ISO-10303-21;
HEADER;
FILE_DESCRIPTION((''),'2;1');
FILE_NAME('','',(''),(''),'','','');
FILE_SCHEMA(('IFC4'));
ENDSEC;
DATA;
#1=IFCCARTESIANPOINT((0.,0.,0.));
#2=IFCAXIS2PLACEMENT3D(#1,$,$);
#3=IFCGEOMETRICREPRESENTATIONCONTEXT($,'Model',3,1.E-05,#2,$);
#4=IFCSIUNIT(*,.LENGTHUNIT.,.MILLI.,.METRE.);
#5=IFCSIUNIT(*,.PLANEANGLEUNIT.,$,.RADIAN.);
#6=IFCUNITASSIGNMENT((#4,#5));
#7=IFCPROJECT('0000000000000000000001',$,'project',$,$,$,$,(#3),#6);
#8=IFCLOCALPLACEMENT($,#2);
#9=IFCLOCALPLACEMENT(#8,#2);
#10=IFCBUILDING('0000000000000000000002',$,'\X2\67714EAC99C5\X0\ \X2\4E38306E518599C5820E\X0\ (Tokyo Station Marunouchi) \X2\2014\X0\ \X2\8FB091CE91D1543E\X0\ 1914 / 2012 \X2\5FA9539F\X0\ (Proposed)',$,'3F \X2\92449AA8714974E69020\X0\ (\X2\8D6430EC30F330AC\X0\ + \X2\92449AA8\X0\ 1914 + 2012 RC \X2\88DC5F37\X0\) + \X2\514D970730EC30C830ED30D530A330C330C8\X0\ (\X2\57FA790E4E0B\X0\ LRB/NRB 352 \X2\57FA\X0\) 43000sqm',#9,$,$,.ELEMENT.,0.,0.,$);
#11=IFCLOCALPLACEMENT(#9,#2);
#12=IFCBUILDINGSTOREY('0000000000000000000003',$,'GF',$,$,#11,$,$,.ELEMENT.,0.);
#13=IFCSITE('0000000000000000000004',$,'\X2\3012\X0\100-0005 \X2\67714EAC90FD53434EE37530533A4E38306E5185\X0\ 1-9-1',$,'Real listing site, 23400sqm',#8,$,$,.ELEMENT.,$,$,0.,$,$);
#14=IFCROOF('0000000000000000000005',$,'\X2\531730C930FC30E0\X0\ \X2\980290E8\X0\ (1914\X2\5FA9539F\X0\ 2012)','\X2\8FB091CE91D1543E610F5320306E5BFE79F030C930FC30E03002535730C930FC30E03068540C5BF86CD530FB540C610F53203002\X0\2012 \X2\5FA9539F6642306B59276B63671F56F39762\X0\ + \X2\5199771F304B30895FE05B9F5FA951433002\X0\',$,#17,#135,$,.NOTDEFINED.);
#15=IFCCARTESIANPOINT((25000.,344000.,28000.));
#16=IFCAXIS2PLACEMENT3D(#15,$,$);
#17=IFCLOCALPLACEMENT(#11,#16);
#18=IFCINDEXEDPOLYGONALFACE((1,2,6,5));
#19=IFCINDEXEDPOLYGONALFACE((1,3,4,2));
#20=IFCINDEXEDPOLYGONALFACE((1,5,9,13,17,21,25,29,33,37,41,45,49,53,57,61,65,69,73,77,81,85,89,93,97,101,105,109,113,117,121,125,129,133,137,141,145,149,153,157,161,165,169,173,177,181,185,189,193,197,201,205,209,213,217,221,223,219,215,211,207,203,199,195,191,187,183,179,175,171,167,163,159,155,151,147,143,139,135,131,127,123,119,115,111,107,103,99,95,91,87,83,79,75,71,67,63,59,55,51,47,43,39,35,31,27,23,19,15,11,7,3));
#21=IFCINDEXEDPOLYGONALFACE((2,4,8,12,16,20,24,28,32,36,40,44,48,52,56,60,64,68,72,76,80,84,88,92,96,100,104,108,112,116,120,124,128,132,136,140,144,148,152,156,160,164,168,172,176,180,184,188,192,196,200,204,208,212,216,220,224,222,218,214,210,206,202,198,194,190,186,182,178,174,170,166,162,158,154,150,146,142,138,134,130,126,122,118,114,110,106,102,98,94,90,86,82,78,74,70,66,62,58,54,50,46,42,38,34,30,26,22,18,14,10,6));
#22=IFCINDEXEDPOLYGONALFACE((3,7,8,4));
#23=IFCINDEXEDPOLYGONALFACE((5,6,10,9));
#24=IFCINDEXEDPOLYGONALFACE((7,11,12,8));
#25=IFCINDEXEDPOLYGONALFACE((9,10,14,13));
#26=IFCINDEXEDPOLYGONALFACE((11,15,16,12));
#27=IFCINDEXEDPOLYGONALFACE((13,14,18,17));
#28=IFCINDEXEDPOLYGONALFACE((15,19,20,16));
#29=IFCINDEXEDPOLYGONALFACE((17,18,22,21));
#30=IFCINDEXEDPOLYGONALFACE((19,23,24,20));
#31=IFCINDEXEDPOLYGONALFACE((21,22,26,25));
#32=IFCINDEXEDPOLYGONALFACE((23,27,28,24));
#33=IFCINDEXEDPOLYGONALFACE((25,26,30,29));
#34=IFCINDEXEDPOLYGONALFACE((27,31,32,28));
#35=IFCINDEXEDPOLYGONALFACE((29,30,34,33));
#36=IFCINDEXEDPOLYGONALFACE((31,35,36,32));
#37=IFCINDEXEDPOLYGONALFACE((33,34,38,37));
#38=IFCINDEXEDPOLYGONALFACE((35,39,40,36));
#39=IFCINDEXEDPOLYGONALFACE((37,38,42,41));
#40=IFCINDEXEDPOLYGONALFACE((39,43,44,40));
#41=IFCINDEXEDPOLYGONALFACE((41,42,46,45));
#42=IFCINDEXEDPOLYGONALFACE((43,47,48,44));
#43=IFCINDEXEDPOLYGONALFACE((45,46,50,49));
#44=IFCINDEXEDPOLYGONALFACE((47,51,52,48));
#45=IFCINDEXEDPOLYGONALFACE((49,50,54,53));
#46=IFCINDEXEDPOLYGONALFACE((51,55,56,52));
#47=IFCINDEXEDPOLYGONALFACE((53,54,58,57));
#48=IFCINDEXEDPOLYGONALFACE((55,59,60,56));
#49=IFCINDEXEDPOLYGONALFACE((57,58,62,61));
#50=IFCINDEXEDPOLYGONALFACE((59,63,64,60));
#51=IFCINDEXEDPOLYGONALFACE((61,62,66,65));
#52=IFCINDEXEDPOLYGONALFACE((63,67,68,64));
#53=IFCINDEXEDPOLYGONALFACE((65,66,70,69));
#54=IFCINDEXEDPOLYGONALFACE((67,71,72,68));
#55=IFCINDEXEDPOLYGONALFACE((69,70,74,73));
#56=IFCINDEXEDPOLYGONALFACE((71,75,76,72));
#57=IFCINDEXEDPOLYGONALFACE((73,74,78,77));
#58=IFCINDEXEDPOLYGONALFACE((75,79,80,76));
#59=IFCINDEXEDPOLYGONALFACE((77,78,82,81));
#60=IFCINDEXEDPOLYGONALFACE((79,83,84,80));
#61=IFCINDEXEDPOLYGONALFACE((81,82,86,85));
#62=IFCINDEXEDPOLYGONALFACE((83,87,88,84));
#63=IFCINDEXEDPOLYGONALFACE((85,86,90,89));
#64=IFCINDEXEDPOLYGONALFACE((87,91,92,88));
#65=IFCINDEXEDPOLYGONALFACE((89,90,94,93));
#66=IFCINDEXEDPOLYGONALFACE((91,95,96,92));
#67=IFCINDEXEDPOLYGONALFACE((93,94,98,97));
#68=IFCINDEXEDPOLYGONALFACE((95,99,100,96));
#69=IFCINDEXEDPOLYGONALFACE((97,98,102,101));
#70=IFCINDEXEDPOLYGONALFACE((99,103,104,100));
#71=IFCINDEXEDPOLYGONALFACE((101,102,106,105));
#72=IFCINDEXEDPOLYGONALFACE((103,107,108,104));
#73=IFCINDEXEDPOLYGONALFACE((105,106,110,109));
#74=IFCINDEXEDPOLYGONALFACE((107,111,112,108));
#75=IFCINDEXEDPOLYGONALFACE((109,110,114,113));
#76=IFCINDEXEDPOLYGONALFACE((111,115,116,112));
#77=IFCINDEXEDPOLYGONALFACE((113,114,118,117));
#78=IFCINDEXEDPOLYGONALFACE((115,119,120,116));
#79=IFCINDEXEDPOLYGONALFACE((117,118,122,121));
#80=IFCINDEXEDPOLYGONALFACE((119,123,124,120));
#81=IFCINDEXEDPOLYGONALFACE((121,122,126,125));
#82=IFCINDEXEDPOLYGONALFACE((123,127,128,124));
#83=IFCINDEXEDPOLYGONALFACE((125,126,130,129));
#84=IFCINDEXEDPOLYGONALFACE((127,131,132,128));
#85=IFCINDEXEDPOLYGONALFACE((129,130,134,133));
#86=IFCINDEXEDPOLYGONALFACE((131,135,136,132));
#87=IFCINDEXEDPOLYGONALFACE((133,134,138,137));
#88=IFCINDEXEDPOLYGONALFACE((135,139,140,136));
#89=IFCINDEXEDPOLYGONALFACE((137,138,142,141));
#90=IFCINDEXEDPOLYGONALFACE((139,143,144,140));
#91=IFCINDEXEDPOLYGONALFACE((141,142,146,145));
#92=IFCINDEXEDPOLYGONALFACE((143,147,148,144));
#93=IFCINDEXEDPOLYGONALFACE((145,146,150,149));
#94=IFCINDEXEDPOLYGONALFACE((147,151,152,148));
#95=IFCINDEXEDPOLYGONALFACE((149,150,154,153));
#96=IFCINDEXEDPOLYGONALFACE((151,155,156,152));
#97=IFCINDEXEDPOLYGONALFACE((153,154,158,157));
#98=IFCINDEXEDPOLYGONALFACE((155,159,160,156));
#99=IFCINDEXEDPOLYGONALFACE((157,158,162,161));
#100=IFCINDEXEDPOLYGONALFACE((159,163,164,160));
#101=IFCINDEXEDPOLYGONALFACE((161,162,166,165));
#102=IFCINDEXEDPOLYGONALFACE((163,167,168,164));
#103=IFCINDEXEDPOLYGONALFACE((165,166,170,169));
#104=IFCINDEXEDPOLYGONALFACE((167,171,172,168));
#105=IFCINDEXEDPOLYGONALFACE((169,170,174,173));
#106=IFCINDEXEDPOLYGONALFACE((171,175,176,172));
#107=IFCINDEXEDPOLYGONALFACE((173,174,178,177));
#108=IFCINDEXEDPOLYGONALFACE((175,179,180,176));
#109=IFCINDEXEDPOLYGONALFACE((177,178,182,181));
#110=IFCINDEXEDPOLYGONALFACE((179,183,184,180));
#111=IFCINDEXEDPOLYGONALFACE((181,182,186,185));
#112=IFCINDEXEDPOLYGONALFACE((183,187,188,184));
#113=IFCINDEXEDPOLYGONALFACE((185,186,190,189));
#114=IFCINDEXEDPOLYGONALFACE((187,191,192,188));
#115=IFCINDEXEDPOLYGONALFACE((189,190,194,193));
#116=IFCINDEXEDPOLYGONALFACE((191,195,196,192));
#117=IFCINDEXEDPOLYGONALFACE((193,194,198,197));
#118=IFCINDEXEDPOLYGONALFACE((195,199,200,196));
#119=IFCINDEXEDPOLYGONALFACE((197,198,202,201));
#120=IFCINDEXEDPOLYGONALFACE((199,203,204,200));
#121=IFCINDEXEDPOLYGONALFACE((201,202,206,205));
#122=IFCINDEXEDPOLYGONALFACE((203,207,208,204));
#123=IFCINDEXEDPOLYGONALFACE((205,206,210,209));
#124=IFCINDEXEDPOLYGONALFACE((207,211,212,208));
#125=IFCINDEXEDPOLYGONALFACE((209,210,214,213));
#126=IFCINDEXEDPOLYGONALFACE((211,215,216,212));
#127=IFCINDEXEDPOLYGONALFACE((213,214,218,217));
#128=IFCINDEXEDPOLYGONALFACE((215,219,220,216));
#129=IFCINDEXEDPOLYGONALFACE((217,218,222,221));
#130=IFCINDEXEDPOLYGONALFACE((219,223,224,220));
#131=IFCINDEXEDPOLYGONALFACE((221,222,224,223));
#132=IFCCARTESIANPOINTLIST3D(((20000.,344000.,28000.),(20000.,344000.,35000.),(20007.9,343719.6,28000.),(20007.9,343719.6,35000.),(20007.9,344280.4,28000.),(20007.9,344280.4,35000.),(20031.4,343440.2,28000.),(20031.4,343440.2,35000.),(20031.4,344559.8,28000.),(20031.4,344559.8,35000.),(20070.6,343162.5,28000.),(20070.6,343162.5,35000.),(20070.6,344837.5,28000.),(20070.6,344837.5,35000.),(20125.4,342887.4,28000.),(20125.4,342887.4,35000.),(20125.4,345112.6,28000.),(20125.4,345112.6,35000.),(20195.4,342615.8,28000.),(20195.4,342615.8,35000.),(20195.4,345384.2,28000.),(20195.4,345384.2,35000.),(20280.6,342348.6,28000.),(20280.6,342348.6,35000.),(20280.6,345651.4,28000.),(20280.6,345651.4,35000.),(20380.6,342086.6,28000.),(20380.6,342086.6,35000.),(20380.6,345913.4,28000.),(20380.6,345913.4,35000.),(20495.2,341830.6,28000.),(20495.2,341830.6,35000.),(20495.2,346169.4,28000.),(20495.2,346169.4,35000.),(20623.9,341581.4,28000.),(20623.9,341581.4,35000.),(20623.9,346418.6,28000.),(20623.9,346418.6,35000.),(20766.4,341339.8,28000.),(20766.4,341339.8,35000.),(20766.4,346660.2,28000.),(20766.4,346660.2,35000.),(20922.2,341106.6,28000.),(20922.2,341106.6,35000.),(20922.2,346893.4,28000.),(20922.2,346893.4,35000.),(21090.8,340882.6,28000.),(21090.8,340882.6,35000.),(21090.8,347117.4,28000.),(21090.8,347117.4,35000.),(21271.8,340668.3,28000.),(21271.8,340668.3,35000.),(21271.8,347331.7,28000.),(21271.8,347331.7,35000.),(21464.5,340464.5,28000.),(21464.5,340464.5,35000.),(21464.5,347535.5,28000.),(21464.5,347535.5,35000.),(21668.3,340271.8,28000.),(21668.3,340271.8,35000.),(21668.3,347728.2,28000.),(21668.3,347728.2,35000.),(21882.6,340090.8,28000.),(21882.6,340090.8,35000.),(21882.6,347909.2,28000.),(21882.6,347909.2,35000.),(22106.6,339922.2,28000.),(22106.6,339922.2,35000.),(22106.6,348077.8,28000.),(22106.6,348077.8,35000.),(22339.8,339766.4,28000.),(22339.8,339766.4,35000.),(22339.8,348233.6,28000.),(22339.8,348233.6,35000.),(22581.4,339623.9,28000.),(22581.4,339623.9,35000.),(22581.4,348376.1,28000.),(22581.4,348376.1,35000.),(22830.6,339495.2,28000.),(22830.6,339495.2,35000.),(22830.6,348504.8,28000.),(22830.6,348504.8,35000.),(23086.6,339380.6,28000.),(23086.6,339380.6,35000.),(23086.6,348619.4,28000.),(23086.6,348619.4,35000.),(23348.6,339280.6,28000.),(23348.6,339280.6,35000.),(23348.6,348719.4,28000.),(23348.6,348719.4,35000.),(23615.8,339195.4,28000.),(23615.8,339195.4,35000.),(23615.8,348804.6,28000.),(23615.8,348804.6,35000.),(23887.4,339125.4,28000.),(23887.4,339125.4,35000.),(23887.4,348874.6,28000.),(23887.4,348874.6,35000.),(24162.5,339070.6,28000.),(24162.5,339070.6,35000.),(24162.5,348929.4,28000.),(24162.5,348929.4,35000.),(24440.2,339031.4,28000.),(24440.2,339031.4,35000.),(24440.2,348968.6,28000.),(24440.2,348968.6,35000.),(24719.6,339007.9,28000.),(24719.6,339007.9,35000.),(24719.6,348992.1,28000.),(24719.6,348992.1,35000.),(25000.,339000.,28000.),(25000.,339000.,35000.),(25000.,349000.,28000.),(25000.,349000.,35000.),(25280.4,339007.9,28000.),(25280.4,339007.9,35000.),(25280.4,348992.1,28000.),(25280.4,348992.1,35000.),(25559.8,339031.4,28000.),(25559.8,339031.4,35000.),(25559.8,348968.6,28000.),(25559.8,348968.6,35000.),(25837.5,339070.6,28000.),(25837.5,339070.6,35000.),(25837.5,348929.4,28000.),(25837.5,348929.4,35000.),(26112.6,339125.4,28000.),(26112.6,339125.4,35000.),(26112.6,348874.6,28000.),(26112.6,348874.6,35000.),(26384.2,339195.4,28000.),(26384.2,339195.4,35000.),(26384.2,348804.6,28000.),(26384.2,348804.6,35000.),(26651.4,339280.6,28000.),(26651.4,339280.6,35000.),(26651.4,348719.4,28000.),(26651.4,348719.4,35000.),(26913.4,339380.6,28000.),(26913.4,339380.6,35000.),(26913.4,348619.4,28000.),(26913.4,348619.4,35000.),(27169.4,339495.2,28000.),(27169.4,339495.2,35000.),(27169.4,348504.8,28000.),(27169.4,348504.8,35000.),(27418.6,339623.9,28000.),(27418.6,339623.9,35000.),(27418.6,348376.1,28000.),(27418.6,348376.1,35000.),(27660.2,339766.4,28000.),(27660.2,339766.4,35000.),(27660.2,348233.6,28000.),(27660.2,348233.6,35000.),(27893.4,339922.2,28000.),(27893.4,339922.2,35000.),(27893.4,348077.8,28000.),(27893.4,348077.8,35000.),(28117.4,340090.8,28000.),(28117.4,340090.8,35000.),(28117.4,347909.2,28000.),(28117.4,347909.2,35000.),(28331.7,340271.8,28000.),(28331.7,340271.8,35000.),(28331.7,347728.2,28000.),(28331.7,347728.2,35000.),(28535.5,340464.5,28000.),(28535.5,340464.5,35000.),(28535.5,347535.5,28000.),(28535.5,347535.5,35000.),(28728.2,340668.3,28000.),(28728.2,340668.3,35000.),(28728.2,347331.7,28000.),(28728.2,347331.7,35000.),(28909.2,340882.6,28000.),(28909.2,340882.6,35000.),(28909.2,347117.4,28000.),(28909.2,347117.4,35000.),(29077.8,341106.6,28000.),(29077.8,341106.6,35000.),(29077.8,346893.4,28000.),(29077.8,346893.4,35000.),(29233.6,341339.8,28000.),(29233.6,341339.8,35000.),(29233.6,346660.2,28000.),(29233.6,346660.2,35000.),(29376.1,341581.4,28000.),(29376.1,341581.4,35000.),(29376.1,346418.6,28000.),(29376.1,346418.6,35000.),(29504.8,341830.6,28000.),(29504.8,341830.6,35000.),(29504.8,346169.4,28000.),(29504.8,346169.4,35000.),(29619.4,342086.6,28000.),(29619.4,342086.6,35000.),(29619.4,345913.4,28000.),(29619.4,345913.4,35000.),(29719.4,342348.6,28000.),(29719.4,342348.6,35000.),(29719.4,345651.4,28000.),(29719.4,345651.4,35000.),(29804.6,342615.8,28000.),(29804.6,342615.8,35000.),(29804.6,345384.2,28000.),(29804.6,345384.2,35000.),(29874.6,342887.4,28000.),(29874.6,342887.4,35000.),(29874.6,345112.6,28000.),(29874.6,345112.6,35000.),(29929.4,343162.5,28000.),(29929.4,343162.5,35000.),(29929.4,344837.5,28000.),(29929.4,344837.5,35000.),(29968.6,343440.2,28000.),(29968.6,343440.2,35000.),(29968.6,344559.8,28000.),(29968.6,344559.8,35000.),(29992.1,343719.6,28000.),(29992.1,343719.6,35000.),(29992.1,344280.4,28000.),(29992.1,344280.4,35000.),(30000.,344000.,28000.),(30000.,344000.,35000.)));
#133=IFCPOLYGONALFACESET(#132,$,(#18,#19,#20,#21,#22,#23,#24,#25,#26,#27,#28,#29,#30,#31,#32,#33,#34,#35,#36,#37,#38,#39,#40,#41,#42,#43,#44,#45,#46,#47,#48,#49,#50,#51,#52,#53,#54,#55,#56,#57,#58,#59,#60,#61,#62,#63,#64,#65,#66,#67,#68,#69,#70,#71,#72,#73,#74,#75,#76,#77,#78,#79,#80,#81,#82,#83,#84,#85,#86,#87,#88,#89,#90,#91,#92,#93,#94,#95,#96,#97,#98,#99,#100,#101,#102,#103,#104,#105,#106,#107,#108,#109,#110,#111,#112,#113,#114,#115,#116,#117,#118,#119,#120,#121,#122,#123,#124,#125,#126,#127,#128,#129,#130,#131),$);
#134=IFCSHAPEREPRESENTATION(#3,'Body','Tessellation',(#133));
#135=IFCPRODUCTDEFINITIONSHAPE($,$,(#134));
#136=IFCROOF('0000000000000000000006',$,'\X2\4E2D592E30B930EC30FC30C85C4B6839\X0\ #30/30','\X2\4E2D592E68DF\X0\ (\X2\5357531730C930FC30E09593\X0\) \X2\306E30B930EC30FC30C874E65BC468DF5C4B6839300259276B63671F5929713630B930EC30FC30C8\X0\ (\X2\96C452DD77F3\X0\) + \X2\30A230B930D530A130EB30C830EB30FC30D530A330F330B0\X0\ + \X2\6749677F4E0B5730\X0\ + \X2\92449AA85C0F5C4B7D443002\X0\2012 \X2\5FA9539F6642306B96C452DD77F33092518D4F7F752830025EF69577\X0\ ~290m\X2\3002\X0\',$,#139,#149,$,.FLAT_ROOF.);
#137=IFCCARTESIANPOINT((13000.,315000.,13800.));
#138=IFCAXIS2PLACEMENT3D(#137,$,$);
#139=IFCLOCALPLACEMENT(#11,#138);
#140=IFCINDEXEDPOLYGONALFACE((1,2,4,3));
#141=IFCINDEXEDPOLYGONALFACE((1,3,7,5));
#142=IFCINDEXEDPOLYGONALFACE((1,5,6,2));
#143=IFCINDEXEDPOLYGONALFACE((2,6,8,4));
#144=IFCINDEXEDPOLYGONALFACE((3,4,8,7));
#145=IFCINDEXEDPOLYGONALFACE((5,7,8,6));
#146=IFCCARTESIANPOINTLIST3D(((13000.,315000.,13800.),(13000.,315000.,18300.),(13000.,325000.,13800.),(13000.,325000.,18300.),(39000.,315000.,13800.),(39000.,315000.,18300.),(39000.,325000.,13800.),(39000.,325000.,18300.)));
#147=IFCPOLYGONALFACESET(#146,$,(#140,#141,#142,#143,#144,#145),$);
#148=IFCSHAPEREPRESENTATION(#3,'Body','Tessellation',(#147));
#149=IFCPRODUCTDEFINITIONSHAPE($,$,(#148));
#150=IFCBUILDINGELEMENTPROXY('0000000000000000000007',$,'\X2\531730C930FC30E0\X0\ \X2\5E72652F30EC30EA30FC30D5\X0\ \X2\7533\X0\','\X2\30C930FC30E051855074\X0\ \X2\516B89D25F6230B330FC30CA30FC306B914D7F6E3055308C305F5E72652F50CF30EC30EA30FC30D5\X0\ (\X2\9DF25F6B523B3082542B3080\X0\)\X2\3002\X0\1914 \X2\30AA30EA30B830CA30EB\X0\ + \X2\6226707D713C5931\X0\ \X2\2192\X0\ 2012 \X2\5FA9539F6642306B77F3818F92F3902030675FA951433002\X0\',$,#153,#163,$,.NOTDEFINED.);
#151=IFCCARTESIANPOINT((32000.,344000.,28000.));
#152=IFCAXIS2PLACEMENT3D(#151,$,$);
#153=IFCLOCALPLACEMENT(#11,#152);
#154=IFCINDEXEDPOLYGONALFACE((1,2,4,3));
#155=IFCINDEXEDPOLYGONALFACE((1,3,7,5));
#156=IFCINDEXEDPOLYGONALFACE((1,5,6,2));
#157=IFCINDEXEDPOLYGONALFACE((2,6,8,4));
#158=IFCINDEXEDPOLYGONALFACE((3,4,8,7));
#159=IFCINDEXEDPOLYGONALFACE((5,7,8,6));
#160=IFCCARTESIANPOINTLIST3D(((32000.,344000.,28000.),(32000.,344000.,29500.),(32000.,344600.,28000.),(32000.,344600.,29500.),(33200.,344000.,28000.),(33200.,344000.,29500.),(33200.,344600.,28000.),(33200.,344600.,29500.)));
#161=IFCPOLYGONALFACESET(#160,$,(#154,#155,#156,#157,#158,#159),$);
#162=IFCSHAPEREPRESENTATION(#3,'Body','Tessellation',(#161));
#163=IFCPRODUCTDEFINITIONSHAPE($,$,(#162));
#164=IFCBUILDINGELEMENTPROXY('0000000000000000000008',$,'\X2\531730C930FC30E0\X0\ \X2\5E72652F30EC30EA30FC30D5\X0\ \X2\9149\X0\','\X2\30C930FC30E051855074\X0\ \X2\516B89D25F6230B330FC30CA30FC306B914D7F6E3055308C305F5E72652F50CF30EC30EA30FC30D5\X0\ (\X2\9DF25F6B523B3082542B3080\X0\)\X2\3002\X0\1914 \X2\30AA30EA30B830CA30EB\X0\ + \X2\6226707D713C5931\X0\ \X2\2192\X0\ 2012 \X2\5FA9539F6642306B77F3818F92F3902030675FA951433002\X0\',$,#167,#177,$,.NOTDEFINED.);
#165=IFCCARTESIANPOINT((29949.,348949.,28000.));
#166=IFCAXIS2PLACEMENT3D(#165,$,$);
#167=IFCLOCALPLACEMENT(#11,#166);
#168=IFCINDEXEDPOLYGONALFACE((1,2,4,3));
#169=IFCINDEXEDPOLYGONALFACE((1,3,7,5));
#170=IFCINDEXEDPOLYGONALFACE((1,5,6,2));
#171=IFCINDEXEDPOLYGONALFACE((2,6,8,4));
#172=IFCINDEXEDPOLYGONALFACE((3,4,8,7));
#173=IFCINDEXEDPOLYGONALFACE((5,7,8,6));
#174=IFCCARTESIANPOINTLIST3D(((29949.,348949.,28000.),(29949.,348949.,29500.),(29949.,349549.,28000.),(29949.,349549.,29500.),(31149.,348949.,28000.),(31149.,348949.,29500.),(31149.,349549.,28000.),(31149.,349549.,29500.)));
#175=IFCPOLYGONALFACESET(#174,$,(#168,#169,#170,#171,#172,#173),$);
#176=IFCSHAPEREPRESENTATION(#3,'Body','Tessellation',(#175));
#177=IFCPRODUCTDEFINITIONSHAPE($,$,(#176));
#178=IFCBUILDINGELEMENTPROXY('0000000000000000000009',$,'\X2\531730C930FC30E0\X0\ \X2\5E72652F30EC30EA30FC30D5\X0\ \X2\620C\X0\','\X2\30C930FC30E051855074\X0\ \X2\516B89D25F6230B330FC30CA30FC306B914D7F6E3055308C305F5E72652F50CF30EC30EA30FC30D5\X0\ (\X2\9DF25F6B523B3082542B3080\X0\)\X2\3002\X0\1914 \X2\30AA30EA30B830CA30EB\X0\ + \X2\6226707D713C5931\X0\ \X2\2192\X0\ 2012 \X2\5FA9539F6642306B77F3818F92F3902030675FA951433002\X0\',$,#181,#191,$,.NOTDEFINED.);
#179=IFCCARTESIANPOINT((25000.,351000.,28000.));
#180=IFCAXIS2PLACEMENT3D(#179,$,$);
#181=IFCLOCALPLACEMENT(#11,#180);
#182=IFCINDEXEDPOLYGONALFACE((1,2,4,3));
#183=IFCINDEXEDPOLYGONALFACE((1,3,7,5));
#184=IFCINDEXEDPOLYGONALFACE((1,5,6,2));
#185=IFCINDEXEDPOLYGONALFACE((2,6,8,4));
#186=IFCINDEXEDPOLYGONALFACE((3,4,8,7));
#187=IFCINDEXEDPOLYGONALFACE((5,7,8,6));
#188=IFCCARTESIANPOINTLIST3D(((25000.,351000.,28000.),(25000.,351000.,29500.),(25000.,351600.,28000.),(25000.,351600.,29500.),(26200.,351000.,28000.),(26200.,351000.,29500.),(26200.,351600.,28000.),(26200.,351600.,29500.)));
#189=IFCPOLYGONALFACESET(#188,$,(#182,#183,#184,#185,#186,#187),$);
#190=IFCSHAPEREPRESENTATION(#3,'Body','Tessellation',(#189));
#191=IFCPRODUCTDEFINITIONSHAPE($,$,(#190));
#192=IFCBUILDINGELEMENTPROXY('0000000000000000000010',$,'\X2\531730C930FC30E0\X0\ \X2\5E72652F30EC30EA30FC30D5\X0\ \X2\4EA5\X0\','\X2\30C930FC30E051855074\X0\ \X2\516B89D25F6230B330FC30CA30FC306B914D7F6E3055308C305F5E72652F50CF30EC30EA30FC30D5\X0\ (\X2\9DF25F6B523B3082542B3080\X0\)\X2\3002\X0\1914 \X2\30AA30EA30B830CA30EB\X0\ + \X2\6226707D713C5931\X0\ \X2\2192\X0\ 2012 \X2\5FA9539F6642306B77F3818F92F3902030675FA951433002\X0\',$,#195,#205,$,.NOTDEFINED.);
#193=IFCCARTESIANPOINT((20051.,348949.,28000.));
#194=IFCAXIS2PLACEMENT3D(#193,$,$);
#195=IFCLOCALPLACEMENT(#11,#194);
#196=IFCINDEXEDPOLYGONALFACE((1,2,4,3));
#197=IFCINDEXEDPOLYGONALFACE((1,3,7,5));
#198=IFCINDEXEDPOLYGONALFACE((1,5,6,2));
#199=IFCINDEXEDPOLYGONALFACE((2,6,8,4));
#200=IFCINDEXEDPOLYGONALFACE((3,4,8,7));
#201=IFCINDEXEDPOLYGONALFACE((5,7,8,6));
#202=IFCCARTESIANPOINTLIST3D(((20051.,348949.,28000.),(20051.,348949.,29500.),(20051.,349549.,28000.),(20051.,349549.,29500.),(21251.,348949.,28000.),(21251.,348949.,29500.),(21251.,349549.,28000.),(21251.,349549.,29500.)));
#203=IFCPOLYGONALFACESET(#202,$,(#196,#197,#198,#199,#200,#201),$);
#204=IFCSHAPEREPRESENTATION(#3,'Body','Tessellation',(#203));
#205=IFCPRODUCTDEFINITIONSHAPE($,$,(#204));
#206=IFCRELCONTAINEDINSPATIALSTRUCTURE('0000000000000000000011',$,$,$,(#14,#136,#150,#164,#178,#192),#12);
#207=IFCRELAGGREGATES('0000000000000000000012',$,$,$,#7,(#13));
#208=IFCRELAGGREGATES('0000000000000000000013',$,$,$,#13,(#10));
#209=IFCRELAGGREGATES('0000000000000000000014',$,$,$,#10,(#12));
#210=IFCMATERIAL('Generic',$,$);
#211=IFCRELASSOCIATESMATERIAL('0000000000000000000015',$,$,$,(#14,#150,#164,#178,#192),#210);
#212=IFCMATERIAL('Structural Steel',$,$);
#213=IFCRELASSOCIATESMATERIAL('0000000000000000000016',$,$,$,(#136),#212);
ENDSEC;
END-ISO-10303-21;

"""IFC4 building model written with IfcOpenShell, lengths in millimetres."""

from ifc_helpers import new_model, si_unit, frame, frame_2d, origin, origin_2d, place, context, project, spatial, rectangle, circle, extrude, material, element, save


model = new_model("IFC4")

# Units and contexts
model_context = context("Model", 3, precision=1e-05, world=origin())
ifc_project = project(units=[si_unit("LENGTHUNIT", "METRE", prefix="MILLI"), si_unit("PLANEANGLEUNIT", "RADIAN")], contexts=[model_context])

# Site, building, storey
site_placement = place(None, origin())
site = spatial("IfcSite", under=ifc_project, at=site_placement, Name="〒100-0005 東京都千代田区丸の内 1-9-1", ObjectType="Real listing site, 23400sqm", CompositionType="ELEMENT", RefElevation=0.0)
building_placement = place(site_placement, origin())
building = spatial("IfcBuilding", under=site, at=building_placement, Name="東京駅 丸の内駅舎 (Tokyo Station Marunouchi) — 辰野金吾 1914 / 2012 復原 (Proposed)", ObjectType="3F 鉄骨煉瓦造 (赤レンガ + 鉄骨 1914 + 2012 RC 補強) + 免震レトロフィット (基礎下 LRB/NRB 352 基) 43000sqm", CompositionType="ELEMENT", ElevationOfRefHeight=0.0, ElevationOfTerrain=0.0)
storey_placement = place(building_placement, origin())
storey = spatial("IfcBuildingStorey", under=building, at=storey_placement, Name="GF", CompositionType="ELEMENT", Elevation=0.0)

# Shared definitions
ifc_material_1 = material(Name="Structural Steel")

# Shared definitions
ifc_material_2 = material(Name="Generic")

# Roofs
roof_1_placement = place(storey_placement, frame((25000.0, 344000.0, 28000.0)))
element("IfcRoof", 1, at=roof_1_placement, inside=storey, material=ifc_material_2, Name="北ドーム 頂部 (1914復原 2012)", Description="辰野金吾意匠の対称ドーム。南ドームと同寸法・同意匠。2012 復原時に大正期図面 + 写真から忠実復元。", PredefinedType="NOTDEFINED", context=model_context, shape_type="SweptSolid", body=[
    extrude(circle(Radius=5000.0, at=origin_2d()), frame((25000.0, 344000.0, 28000.0)), (0.0, 0.0, 1.0), 7000.0),
])
roof_2_placement = place(storey_placement, frame((13000.0, 315000.0, 13800.0)))
element("IfcRoof", 2, at=roof_2_placement, inside=storey, material=ifc_material_1, Name="中央スレート屋根 #30/30", Description="中央棟 (南北ドーム間) のスレート瓦寄棟屋根。大正期天然スレート (雄勝石) + アスファルトルーフィング + 杉板下地 + 鉄骨小屋組。2012 復原時に雄勝石を再使用。延長 ~290m。", PredefinedType="FLAT_ROOF", context=model_context, shape_type="SweptSolid", body=[
    extrude(rectangle(XDim=26000.0, YDim=10000.0, at=frame_2d((13000.0, 5000.0))), frame((13000.0, 315000.0, 13800.0)), (0.0, 0.0, 1.0), 4500.0),
])

# Building element proxies
proxy_1_placement = place(storey_placement, frame((32000.0, 344000.0, 28000.0)))
element("IfcBuildingElementProxy", 3, at=proxy_1_placement, inside=storey, material=ifc_material_2, Name="北ドーム 干支レリーフ 申", Description="ドーム内側 八角形コーナーに配置された干支像レリーフ (鷲彫刻も含む)。1914 オリジナル + 戦災焼失 → 2012 復原時に石膏鋳造で復元。", PredefinedType="NOTDEFINED", context=model_context, shape_type="SweptSolid", body=[
    extrude(rectangle(XDim=1200.0, YDim=600.0, at=frame_2d((600.0, 300.0))), frame((32000.0, 344000.0, 28000.0)), (0.0, 0.0, 1.0), 1500.0),
])
proxy_2_placement = place(storey_placement, frame((29949.0, 348949.0, 28000.0)))
element("IfcBuildingElementProxy", 4, at=proxy_2_placement, inside=storey, material=ifc_material_2, Name="北ドーム 干支レリーフ 酉", Description="ドーム内側 八角形コーナーに配置された干支像レリーフ (鷲彫刻も含む)。1914 オリジナル + 戦災焼失 → 2012 復原時に石膏鋳造で復元。", PredefinedType="NOTDEFINED", context=model_context, shape_type="SweptSolid", body=[
    extrude(rectangle(XDim=1200.0, YDim=600.0, at=frame_2d((600.0, 300.0))), frame((29949.0, 348949.0, 28000.0)), (0.0, 0.0, 1.0), 1500.0),
])
proxy_3_placement = place(storey_placement, frame((25000.0, 351000.0, 28000.0)))
element("IfcBuildingElementProxy", 5, at=proxy_3_placement, inside=storey, material=ifc_material_2, Name="北ドーム 干支レリーフ 戌", Description="ドーム内側 八角形コーナーに配置された干支像レリーフ (鷲彫刻も含む)。1914 オリジナル + 戦災焼失 → 2012 復原時に石膏鋳造で復元。", PredefinedType="NOTDEFINED", context=model_context, shape_type="SweptSolid", body=[
    extrude(rectangle(XDim=1200.0, YDim=600.0, at=frame_2d((600.0, 300.0))), frame((25000.0, 351000.0, 28000.0)), (0.0, 0.0, 1.0), 1500.0),
])
proxy_4_placement = place(storey_placement, frame((20051.0, 348949.0, 28000.0)))
element("IfcBuildingElementProxy", 6, at=proxy_4_placement, inside=storey, material=ifc_material_2, Name="北ドーム 干支レリーフ 亥", Description="ドーム内側 八角形コーナーに配置された干支像レリーフ (鷲彫刻も含む)。1914 オリジナル + 戦災焼失 → 2012 復原時に石膏鋳造で復元。", PredefinedType="NOTDEFINED", context=model_context, shape_type="SweptSolid", body=[
    extrude(rectangle(XDim=1200.0, YDim=600.0, at=frame_2d((600.0, 300.0))), frame((20051.0, 348949.0, 28000.0)), (0.0, 0.0, 1.0), 1500.0),
])

save(model, "model.ifc")
